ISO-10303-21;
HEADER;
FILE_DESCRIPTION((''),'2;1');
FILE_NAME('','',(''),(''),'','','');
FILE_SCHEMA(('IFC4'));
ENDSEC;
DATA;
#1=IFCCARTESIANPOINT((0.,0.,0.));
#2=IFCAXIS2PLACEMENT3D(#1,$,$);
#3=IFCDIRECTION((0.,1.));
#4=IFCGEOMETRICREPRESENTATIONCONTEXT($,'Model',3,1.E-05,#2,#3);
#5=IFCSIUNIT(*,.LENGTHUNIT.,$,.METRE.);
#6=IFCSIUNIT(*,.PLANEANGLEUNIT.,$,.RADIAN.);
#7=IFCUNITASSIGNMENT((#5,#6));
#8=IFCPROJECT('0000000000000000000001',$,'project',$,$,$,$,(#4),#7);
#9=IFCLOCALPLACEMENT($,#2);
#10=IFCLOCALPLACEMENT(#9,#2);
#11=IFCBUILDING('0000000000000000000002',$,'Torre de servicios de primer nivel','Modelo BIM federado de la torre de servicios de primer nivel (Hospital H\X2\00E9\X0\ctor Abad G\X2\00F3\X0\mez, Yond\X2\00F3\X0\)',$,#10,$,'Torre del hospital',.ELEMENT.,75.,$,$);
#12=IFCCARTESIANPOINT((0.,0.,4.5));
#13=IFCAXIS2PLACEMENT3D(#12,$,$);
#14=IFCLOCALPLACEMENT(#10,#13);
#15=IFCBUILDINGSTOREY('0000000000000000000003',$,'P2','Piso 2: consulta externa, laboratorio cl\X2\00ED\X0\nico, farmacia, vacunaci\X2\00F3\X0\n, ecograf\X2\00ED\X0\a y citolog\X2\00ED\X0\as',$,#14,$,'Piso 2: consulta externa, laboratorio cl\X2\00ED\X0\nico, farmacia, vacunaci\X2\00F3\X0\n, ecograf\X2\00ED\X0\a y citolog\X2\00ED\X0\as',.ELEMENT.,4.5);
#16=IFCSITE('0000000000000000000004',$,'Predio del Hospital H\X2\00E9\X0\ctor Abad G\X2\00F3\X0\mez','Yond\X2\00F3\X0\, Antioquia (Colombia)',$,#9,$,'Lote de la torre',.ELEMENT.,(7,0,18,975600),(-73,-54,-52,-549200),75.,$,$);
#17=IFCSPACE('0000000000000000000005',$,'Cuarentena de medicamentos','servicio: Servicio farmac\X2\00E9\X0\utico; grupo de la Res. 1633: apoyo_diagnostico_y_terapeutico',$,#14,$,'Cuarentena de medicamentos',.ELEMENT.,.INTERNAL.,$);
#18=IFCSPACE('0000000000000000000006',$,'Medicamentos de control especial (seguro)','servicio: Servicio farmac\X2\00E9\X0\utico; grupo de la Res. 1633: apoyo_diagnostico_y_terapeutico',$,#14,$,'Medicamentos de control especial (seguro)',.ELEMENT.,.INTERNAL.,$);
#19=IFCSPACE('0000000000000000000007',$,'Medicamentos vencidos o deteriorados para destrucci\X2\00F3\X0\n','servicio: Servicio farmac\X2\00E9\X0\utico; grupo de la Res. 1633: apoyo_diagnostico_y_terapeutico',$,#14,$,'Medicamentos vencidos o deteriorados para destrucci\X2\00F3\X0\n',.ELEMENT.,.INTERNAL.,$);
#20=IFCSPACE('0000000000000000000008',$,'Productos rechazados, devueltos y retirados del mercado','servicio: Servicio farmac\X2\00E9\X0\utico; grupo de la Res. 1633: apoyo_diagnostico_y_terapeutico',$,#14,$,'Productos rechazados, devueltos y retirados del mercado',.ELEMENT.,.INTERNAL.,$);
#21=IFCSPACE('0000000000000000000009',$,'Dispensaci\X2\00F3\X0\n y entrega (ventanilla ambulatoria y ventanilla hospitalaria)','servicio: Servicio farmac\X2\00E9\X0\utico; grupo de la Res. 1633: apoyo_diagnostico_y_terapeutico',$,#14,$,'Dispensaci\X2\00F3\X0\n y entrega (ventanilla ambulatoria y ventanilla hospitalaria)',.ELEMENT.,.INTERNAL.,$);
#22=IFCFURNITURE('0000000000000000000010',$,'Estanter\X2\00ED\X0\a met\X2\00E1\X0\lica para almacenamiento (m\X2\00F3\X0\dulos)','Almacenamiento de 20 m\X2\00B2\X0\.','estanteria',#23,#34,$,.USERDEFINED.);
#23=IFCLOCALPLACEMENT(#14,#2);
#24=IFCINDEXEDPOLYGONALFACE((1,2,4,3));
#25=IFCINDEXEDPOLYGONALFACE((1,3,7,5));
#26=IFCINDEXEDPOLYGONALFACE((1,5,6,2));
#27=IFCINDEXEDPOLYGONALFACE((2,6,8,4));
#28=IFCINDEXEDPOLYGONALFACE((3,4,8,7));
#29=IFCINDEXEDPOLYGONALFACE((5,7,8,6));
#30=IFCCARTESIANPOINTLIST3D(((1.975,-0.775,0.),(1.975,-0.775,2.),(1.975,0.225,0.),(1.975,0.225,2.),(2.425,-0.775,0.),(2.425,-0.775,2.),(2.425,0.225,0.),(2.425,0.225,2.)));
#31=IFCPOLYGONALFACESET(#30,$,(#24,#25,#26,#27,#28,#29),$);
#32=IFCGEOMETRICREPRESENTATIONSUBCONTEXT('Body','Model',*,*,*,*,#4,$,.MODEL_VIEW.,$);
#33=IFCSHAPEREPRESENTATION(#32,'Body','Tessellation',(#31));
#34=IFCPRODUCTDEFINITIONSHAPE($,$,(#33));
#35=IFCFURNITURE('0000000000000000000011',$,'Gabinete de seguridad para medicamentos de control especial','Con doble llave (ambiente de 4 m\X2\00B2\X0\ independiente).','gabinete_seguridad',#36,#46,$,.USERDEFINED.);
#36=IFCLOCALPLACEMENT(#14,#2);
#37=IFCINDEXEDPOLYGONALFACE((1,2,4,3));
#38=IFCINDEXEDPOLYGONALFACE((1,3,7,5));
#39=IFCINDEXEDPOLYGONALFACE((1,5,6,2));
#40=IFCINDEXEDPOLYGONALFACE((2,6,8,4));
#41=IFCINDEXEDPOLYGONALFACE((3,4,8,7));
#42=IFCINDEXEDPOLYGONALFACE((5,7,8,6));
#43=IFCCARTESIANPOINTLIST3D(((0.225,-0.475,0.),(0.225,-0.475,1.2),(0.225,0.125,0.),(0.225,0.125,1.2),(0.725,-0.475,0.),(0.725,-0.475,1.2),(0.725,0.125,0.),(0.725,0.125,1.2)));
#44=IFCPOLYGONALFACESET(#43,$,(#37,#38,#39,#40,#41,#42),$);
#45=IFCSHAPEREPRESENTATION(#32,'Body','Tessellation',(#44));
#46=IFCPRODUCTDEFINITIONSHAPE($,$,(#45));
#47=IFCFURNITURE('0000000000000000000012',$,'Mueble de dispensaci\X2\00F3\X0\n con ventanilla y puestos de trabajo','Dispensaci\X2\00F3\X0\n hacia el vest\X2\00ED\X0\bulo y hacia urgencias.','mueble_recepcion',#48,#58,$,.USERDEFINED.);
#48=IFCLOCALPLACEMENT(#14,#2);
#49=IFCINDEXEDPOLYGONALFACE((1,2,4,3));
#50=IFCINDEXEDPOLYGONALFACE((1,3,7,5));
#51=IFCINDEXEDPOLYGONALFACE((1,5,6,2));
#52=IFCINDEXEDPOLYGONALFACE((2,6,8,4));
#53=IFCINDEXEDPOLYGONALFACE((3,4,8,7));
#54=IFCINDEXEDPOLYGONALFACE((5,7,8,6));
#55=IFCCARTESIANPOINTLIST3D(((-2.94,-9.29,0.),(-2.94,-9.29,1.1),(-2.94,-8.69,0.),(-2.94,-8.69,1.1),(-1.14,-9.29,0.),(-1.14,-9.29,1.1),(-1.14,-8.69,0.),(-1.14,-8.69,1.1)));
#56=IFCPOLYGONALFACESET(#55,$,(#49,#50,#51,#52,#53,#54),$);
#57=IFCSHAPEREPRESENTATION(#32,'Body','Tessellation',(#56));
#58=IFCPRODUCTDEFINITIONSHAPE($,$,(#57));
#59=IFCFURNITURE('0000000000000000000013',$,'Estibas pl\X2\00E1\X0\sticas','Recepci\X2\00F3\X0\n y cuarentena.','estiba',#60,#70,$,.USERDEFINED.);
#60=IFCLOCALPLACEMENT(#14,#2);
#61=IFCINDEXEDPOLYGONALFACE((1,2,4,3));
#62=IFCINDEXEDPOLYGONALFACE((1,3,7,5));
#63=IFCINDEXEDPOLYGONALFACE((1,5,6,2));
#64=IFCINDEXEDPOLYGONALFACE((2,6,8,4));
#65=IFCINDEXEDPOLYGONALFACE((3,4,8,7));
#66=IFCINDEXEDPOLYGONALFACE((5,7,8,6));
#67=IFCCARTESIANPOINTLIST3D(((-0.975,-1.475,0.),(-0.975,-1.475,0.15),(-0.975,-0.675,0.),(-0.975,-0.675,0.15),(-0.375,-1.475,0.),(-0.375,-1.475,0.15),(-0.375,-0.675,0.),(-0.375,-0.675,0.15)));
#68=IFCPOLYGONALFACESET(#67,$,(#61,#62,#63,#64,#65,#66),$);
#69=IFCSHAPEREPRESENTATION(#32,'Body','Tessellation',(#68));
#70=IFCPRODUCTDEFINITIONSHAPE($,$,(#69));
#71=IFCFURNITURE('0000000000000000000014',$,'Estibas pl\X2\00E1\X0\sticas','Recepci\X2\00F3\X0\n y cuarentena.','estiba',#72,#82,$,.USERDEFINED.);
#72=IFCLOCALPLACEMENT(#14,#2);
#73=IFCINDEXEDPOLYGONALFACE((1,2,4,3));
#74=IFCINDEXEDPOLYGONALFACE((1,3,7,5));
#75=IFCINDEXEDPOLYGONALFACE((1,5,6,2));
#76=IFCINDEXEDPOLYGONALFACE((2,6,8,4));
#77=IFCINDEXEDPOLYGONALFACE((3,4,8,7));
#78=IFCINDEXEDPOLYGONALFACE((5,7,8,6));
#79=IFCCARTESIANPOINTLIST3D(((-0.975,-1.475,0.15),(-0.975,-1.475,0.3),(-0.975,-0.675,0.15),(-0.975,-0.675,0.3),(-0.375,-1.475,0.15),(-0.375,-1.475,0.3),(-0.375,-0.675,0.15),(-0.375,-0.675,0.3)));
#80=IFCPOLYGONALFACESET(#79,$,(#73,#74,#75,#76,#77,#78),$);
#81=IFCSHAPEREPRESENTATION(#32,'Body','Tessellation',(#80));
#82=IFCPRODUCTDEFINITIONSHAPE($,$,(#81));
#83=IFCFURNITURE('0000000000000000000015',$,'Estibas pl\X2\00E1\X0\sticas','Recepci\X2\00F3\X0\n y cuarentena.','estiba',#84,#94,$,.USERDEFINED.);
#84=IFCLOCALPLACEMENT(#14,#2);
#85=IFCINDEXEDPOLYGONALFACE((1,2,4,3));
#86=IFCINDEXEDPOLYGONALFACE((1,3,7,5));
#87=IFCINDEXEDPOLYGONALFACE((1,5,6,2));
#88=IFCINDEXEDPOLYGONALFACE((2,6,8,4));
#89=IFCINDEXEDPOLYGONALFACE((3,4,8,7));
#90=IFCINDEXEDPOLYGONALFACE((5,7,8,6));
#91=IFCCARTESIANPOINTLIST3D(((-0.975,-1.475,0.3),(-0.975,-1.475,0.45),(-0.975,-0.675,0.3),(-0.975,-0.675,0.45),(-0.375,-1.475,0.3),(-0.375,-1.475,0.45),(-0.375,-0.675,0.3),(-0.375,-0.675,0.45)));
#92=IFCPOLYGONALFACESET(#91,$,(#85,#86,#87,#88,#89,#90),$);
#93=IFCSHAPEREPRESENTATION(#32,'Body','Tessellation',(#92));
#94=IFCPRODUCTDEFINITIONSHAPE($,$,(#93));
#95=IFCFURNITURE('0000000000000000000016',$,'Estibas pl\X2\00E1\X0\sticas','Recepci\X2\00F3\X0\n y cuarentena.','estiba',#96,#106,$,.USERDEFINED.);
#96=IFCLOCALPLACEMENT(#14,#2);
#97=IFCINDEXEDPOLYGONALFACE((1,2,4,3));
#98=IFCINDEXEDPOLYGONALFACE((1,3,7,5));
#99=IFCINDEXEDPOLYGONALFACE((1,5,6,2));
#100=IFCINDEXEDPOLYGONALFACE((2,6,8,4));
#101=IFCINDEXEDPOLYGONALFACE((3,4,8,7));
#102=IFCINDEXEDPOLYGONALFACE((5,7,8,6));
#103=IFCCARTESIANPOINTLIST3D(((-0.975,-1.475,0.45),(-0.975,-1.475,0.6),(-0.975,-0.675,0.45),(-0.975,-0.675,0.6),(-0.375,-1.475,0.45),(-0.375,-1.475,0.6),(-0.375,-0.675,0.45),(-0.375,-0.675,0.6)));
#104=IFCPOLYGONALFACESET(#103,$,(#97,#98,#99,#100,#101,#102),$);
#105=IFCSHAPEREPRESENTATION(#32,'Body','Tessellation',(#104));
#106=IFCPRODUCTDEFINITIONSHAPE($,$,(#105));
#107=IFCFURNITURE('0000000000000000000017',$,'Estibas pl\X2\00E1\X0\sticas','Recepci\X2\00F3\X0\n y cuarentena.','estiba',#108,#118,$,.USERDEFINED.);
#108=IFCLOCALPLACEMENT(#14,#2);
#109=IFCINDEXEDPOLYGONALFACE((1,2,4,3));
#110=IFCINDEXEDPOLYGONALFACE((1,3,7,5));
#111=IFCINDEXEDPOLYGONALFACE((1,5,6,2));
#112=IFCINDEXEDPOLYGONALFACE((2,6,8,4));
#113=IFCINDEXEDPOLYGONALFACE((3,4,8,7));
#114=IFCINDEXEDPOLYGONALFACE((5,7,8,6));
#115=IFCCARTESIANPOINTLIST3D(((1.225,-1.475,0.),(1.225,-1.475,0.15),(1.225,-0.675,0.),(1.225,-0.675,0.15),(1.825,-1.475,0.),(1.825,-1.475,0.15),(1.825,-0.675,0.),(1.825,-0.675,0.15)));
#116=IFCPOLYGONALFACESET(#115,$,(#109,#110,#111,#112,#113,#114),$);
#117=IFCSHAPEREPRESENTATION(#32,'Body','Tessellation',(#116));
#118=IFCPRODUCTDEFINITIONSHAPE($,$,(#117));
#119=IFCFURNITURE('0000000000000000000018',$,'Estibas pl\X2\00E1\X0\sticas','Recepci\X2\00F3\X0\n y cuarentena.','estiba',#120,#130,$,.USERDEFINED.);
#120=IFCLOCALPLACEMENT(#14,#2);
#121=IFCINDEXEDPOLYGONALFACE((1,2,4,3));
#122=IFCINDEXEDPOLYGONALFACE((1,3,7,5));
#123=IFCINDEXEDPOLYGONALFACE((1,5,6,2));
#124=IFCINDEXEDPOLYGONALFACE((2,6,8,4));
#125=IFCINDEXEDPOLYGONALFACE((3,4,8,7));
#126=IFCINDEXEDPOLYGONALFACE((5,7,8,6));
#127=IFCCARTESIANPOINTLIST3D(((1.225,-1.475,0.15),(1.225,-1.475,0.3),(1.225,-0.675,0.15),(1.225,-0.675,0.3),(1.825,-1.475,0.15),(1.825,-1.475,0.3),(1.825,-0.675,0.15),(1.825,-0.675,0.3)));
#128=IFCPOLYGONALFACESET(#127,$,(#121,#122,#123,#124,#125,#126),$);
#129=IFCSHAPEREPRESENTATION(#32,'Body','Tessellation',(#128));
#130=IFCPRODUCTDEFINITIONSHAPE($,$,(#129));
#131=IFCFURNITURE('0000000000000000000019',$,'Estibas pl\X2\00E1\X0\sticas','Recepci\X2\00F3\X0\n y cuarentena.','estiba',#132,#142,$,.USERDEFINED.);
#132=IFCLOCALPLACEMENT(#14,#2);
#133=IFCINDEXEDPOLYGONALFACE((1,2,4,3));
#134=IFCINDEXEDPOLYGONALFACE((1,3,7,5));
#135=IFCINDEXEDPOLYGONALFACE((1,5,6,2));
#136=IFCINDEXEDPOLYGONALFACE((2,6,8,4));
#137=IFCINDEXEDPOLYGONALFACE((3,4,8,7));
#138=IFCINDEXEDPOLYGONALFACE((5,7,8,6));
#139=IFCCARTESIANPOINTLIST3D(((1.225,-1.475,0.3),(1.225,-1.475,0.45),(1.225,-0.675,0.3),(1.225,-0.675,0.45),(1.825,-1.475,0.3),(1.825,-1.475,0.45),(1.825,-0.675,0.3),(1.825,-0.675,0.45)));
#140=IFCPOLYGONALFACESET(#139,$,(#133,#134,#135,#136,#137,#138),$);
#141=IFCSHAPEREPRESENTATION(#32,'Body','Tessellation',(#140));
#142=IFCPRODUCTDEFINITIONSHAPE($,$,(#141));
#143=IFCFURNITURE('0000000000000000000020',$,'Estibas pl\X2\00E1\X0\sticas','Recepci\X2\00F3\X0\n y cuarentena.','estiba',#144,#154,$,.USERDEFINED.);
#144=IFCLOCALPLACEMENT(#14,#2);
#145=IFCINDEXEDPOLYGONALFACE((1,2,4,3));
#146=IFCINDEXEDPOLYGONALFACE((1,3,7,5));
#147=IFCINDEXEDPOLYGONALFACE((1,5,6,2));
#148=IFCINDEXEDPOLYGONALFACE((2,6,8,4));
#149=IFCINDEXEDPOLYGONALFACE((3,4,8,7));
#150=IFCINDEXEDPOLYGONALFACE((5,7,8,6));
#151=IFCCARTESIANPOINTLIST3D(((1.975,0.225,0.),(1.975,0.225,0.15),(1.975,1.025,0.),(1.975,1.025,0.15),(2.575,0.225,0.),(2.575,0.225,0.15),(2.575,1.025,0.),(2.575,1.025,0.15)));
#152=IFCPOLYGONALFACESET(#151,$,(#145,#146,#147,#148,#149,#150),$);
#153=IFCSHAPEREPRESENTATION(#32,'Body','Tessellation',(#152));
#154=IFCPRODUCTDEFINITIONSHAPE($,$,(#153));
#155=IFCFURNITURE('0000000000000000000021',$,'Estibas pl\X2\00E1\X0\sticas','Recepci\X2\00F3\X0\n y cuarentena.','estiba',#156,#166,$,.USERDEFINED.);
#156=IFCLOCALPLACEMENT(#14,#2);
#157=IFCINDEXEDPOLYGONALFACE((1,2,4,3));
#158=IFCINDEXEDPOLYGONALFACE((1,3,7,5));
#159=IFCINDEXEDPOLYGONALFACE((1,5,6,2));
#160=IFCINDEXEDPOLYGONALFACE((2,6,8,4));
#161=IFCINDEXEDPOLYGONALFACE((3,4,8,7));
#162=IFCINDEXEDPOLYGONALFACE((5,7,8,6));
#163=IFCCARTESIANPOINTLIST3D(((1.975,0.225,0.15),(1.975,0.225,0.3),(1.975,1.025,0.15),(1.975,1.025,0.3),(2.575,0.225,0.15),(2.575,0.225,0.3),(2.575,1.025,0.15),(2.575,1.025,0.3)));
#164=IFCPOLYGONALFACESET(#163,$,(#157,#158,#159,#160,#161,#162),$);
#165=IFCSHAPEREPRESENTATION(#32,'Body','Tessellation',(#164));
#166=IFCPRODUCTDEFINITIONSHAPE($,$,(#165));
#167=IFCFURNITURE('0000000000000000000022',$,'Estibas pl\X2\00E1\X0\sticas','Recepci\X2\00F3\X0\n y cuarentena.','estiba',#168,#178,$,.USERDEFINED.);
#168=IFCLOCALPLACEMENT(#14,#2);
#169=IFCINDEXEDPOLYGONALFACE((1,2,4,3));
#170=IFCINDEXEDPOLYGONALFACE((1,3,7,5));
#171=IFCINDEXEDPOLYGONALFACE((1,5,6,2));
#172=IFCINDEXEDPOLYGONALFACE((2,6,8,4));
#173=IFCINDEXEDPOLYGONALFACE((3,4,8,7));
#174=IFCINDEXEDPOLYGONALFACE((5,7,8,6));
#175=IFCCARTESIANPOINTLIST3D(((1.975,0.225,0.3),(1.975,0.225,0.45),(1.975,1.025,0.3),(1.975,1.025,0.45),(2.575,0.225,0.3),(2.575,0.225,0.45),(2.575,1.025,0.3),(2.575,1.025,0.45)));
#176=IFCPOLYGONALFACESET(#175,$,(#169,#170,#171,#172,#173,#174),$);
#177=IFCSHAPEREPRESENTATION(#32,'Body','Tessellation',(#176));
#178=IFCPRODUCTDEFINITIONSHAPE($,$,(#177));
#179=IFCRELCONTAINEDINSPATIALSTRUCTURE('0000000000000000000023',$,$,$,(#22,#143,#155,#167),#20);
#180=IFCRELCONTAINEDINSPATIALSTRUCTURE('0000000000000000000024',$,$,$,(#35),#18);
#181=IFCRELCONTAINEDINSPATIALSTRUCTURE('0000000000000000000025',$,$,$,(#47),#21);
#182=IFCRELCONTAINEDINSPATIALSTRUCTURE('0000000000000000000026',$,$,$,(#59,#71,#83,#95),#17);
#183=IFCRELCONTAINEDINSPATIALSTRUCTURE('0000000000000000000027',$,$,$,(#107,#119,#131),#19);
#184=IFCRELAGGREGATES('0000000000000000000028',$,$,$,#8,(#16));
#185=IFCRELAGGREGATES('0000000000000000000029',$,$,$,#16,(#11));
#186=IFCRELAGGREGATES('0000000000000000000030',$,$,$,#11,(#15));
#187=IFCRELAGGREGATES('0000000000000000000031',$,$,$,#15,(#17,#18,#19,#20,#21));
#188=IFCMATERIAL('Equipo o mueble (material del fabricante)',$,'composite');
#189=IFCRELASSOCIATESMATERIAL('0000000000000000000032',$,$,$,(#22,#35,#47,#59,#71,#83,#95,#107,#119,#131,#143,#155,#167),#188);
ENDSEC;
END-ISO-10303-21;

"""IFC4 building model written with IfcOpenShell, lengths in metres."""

from ifc_helpers import new_model, si_unit, direction, frame, origin, place, context, subcontext, project, spatial, rectangle, extrude, material, element, save


model = new_model("IFC4")

# Units and contexts
model_context = context("Model", 3, precision=1e-05, world=origin(), true_north=direction((0.0, 1.0)))
body_context = subcontext(model_context, "Body", "Model", "MODEL_VIEW")
ifc_project = project(units=[si_unit("LENGTHUNIT", "METRE"), si_unit("PLANEANGLEUNIT", "RADIAN")], contexts=[model_context])

# Site, building, storey
site_placement = place(None, origin())
site = spatial("IfcSite", under=ifc_project, at=site_placement, Name="Predio del Hospital Héctor Abad Gómez", Description="Yondó, Antioquia (Colombia)", LongName="Lote de la torre", CompositionType="ELEMENT", RefLatitude=(7, 0, 18, 975600), RefLongitude=(-73, -54, -52, -549200), RefElevation=75.0)
building_placement = place(site_placement, origin())
building = spatial("IfcBuilding", under=site, at=building_placement, Name="Torre de servicios de primer nivel", Description="Modelo BIM federado de la torre de servicios de primer nivel (Hospital Héctor Abad Gómez, Yondó)", LongName="Torre del hospital", CompositionType="ELEMENT", ElevationOfRefHeight=75.0)
placement = place(building_placement, frame((0.0, 0.0, 4.5)))
storey = spatial("IfcBuildingStorey", under=building, at=placement, Name="P2", Description="Piso 2: consulta externa, laboratorio clínico, farmacia, vacunación, ecografía y citologías", LongName="Piso 2: consulta externa, laboratorio clínico, farmacia, vacunación, ecografía y citologías", CompositionType="ELEMENT", Elevation=4.5)

# Shared definitions
ifc_material = material(Name="Equipo o mueble (material del fabricante)", Category="composite")

# Shared definitions
space_1 = spatial("IfcSpace", under=storey, at=placement, Name="Cuarentena de medicamentos", Description="servicio: Servicio farmacéutico; grupo de la Res. 1633: apoyo_diagnostico_y_terapeutico", LongName="Cuarentena de medicamentos", CompositionType="ELEMENT", PredefinedType="INTERNAL")

# Shared definitions
space_2 = spatial("IfcSpace", under=storey, at=placement, Name="Medicamentos de control especial (seguro)", Description="servicio: Servicio farmacéutico; grupo de la Res. 1633: apoyo_diagnostico_y_terapeutico", LongName="Medicamentos de control especial (seguro)", CompositionType="ELEMENT", PredefinedType="INTERNAL")

# Shared definitions
space_3 = spatial("IfcSpace", under=storey, at=placement, Name="Medicamentos vencidos o deteriorados para destrucción", Description="servicio: Servicio farmacéutico; grupo de la Res. 1633: apoyo_diagnostico_y_terapeutico", LongName="Medicamentos vencidos o deteriorados para destrucción", CompositionType="ELEMENT", PredefinedType="INTERNAL")

# Shared definitions
space_4 = spatial("IfcSpace", under=storey, at=placement, Name="Productos rechazados, devueltos y retirados del mercado", Description="servicio: Servicio farmacéutico; grupo de la Res. 1633: apoyo_diagnostico_y_terapeutico", LongName="Productos rechazados, devueltos y retirados del mercado", CompositionType="ELEMENT", PredefinedType="INTERNAL")

# Furniture
element("IfcFurniture", 1, at=placement, inside=space_4, material=ifc_material, Name="Estantería metálica para almacenamiento (módulos)", Description="Almacenamiento de 20 m².", ObjectType="estanteria", PredefinedType="USERDEFINED", context=body_context, shape_type="SweptSolid", body=[
    extrude(rectangle(XDim=1.0, YDim=0.45), frame((2.2, -0.275, 0.0), z_axis=(0.0, 0.0, 1.0), x_axis=(0.0, -1.0, 0.0)), (0.0, 0.0, 1.0), 2.0),
])
element("IfcFurniture", 2, at=placement, inside=space_2, material=ifc_material, Name="Gabinete de seguridad para medicamentos de control especial", Description="Con doble llave (ambiente de 4 m² independiente).", ObjectType="gabinete_seguridad", PredefinedType="USERDEFINED", context=body_context, shape_type="SweptSolid", body=[
    extrude(rectangle(XDim=0.6, YDim=0.5), frame((0.475, -0.175, 0.0), z_axis=(0.0, 0.0, 1.0), x_axis=(0.0, 1.0, 0.0)), (0.0, 0.0, 1.0), 1.2),
])

# Shared definitions
space_5 = spatial("IfcSpace", under=storey, at=placement, Name="Dispensación y entrega (ventanilla ambulatoria y ventanilla hospitalaria)", Description="servicio: Servicio farmacéutico; grupo de la Res. 1633: apoyo_diagnostico_y_terapeutico", LongName="Dispensación y entrega (ventanilla ambulatoria y ventanilla hospitalaria)", CompositionType="ELEMENT", PredefinedType="INTERNAL")

# Furniture
element("IfcFurniture", 3, at=placement, inside=space_5, material=ifc_material, Name="Mueble de dispensación con ventanilla y puestos de trabajo", Description="Dispensación hacia el vestíbulo y hacia urgencias.", ObjectType="mueble_recepcion", PredefinedType="USERDEFINED", context=body_context, shape_type="SweptSolid", body=[
    extrude(rectangle(XDim=1.8, YDim=0.6), frame((-2.04, -8.99, 0.0)), (0.0, 0.0, 1.0), 1.1),
])
element("IfcFurniture", 4, at=placement, inside=space_1, material=ifc_material, Name="Estibas plásticas", Description="Recepción y cuarentena.", ObjectType="estiba", PredefinedType="USERDEFINED", context=body_context, shape_type="SweptSolid", body=[
    extrude(rectangle(XDim=0.8, YDim=0.6), frame((-0.675, -1.075, 0.0), z_axis=(0.0, 0.0, 1.0), x_axis=(0.0, 1.0, 0.0)), (0.0, 0.0, 1.0), 0.15),
])
element("IfcFurniture", 5, at=placement, inside=space_1, material=ifc_material, Name="Estibas plásticas", Description="Recepción y cuarentena.", ObjectType="estiba", PredefinedType="USERDEFINED", context=body_context, shape_type="SweptSolid", body=[
    extrude(rectangle(XDim=0.8, YDim=0.6), frame((-0.675, -1.075, 0.15), z_axis=(0.0, 0.0, 1.0), x_axis=(0.0, 1.0, 0.0)), (0.0, 0.0, 1.0), 0.15),
])
element("IfcFurniture", 6, at=placement, inside=space_1, material=ifc_material, Name="Estibas plásticas", Description="Recepción y cuarentena.", ObjectType="estiba", PredefinedType="USERDEFINED", context=body_context, shape_type="SweptSolid", body=[
    extrude(rectangle(XDim=0.8, YDim=0.6), frame((-0.675, -1.075, 0.3), z_axis=(0.0, 0.0, 1.0), x_axis=(0.0, 1.0, 0.0)), (0.0, 0.0, 1.0), 0.15),
])
element("IfcFurniture", 7, at=placement, inside=space_1, material=ifc_material, Name="Estibas plásticas", Description="Recepción y cuarentena.", ObjectType="estiba", PredefinedType="USERDEFINED", context=body_context, shape_type="SweptSolid", body=[
    extrude(rectangle(XDim=0.8, YDim=0.6), frame((-0.675, -1.075, 0.45), z_axis=(0.0, 0.0, 1.0), x_axis=(0.0, 1.0, 0.0)), (0.0, 0.0, 1.0), 0.15),
])
element("IfcFurniture", 8, at=placement, inside=space_3, material=ifc_material, Name="Estibas plásticas", Description="Recepción y cuarentena.", ObjectType="estiba", PredefinedType="USERDEFINED", context=body_context, shape_type="SweptSolid", body=[
    extrude(rectangle(XDim=0.8, YDim=0.6), frame((1.525, -1.075, 0.0), z_axis=(0.0, 0.0, 1.0), x_axis=(0.0, 1.0, 0.0)), (0.0, 0.0, 1.0), 0.15),
])
element("IfcFurniture", 9, at=placement, inside=space_3, material=ifc_material, Name="Estibas plásticas", Description="Recepción y cuarentena.", ObjectType="estiba", PredefinedType="USERDEFINED", context=body_context, shape_type="SweptSolid", body=[
    extrude(rectangle(XDim=0.8, YDim=0.6), frame((1.525, -1.075, 0.15), z_axis=(0.0, 0.0, 1.0), x_axis=(0.0, 1.0, 0.0)), (0.0, 0.0, 1.0), 0.15),
])
element("IfcFurniture", 10, at=placement, inside=space_3, material=ifc_material, Name="Estibas plásticas", Description="Recepción y cuarentena.", ObjectType="estiba", PredefinedType="USERDEFINED", context=body_context, shape_type="SweptSolid", body=[
    extrude(rectangle(XDim=0.8, YDim=0.6), frame((1.525, -1.075, 0.3), z_axis=(0.0, 0.0, 1.0), x_axis=(0.0, 1.0, 0.0)), (0.0, 0.0, 1.0), 0.15),
])
element("IfcFurniture", 11, at=placement, inside=space_4, material=ifc_material, Name="Estibas plásticas", Description="Recepción y cuarentena.", ObjectType="estiba", PredefinedType="USERDEFINED", context=body_context, shape_type="SweptSolid", body=[
    extrude(rectangle(XDim=0.8, YDim=0.6), frame((2.275, 0.625, 0.0), z_axis=(0.0, 0.0, 1.0), x_axis=(0.0, -1.0, 0.0)), (0.0, 0.0, 1.0), 0.15),
])
element("IfcFurniture", 12, at=placement, inside=space_4, material=ifc_material, Name="Estibas plásticas", Description="Recepción y cuarentena.", ObjectType="estiba", PredefinedType="USERDEFINED", context=body_context, shape_type="SweptSolid", body=[
    extrude(rectangle(XDim=0.8, YDim=0.6), frame((2.275, 0.625, 0.15), z_axis=(0.0, 0.0, 1.0), x_axis=(0.0, -1.0, 0.0)), (0.0, 0.0, 1.0), 0.15),
])
element("IfcFurniture", 13, at=placement, inside=space_4, material=ifc_material, Name="Estibas plásticas", Description="Recepción y cuarentena.", ObjectType="estiba", PredefinedType="USERDEFINED", context=body_context, shape_type="SweptSolid", body=[
    extrude(rectangle(XDim=0.8, YDim=0.6), frame((2.275, 0.625, 0.3), z_axis=(0.0, 0.0, 1.0), x_axis=(0.0, -1.0, 0.0)), (0.0, 0.0, 1.0), 0.15),
])

save(model, "model.ifc")
